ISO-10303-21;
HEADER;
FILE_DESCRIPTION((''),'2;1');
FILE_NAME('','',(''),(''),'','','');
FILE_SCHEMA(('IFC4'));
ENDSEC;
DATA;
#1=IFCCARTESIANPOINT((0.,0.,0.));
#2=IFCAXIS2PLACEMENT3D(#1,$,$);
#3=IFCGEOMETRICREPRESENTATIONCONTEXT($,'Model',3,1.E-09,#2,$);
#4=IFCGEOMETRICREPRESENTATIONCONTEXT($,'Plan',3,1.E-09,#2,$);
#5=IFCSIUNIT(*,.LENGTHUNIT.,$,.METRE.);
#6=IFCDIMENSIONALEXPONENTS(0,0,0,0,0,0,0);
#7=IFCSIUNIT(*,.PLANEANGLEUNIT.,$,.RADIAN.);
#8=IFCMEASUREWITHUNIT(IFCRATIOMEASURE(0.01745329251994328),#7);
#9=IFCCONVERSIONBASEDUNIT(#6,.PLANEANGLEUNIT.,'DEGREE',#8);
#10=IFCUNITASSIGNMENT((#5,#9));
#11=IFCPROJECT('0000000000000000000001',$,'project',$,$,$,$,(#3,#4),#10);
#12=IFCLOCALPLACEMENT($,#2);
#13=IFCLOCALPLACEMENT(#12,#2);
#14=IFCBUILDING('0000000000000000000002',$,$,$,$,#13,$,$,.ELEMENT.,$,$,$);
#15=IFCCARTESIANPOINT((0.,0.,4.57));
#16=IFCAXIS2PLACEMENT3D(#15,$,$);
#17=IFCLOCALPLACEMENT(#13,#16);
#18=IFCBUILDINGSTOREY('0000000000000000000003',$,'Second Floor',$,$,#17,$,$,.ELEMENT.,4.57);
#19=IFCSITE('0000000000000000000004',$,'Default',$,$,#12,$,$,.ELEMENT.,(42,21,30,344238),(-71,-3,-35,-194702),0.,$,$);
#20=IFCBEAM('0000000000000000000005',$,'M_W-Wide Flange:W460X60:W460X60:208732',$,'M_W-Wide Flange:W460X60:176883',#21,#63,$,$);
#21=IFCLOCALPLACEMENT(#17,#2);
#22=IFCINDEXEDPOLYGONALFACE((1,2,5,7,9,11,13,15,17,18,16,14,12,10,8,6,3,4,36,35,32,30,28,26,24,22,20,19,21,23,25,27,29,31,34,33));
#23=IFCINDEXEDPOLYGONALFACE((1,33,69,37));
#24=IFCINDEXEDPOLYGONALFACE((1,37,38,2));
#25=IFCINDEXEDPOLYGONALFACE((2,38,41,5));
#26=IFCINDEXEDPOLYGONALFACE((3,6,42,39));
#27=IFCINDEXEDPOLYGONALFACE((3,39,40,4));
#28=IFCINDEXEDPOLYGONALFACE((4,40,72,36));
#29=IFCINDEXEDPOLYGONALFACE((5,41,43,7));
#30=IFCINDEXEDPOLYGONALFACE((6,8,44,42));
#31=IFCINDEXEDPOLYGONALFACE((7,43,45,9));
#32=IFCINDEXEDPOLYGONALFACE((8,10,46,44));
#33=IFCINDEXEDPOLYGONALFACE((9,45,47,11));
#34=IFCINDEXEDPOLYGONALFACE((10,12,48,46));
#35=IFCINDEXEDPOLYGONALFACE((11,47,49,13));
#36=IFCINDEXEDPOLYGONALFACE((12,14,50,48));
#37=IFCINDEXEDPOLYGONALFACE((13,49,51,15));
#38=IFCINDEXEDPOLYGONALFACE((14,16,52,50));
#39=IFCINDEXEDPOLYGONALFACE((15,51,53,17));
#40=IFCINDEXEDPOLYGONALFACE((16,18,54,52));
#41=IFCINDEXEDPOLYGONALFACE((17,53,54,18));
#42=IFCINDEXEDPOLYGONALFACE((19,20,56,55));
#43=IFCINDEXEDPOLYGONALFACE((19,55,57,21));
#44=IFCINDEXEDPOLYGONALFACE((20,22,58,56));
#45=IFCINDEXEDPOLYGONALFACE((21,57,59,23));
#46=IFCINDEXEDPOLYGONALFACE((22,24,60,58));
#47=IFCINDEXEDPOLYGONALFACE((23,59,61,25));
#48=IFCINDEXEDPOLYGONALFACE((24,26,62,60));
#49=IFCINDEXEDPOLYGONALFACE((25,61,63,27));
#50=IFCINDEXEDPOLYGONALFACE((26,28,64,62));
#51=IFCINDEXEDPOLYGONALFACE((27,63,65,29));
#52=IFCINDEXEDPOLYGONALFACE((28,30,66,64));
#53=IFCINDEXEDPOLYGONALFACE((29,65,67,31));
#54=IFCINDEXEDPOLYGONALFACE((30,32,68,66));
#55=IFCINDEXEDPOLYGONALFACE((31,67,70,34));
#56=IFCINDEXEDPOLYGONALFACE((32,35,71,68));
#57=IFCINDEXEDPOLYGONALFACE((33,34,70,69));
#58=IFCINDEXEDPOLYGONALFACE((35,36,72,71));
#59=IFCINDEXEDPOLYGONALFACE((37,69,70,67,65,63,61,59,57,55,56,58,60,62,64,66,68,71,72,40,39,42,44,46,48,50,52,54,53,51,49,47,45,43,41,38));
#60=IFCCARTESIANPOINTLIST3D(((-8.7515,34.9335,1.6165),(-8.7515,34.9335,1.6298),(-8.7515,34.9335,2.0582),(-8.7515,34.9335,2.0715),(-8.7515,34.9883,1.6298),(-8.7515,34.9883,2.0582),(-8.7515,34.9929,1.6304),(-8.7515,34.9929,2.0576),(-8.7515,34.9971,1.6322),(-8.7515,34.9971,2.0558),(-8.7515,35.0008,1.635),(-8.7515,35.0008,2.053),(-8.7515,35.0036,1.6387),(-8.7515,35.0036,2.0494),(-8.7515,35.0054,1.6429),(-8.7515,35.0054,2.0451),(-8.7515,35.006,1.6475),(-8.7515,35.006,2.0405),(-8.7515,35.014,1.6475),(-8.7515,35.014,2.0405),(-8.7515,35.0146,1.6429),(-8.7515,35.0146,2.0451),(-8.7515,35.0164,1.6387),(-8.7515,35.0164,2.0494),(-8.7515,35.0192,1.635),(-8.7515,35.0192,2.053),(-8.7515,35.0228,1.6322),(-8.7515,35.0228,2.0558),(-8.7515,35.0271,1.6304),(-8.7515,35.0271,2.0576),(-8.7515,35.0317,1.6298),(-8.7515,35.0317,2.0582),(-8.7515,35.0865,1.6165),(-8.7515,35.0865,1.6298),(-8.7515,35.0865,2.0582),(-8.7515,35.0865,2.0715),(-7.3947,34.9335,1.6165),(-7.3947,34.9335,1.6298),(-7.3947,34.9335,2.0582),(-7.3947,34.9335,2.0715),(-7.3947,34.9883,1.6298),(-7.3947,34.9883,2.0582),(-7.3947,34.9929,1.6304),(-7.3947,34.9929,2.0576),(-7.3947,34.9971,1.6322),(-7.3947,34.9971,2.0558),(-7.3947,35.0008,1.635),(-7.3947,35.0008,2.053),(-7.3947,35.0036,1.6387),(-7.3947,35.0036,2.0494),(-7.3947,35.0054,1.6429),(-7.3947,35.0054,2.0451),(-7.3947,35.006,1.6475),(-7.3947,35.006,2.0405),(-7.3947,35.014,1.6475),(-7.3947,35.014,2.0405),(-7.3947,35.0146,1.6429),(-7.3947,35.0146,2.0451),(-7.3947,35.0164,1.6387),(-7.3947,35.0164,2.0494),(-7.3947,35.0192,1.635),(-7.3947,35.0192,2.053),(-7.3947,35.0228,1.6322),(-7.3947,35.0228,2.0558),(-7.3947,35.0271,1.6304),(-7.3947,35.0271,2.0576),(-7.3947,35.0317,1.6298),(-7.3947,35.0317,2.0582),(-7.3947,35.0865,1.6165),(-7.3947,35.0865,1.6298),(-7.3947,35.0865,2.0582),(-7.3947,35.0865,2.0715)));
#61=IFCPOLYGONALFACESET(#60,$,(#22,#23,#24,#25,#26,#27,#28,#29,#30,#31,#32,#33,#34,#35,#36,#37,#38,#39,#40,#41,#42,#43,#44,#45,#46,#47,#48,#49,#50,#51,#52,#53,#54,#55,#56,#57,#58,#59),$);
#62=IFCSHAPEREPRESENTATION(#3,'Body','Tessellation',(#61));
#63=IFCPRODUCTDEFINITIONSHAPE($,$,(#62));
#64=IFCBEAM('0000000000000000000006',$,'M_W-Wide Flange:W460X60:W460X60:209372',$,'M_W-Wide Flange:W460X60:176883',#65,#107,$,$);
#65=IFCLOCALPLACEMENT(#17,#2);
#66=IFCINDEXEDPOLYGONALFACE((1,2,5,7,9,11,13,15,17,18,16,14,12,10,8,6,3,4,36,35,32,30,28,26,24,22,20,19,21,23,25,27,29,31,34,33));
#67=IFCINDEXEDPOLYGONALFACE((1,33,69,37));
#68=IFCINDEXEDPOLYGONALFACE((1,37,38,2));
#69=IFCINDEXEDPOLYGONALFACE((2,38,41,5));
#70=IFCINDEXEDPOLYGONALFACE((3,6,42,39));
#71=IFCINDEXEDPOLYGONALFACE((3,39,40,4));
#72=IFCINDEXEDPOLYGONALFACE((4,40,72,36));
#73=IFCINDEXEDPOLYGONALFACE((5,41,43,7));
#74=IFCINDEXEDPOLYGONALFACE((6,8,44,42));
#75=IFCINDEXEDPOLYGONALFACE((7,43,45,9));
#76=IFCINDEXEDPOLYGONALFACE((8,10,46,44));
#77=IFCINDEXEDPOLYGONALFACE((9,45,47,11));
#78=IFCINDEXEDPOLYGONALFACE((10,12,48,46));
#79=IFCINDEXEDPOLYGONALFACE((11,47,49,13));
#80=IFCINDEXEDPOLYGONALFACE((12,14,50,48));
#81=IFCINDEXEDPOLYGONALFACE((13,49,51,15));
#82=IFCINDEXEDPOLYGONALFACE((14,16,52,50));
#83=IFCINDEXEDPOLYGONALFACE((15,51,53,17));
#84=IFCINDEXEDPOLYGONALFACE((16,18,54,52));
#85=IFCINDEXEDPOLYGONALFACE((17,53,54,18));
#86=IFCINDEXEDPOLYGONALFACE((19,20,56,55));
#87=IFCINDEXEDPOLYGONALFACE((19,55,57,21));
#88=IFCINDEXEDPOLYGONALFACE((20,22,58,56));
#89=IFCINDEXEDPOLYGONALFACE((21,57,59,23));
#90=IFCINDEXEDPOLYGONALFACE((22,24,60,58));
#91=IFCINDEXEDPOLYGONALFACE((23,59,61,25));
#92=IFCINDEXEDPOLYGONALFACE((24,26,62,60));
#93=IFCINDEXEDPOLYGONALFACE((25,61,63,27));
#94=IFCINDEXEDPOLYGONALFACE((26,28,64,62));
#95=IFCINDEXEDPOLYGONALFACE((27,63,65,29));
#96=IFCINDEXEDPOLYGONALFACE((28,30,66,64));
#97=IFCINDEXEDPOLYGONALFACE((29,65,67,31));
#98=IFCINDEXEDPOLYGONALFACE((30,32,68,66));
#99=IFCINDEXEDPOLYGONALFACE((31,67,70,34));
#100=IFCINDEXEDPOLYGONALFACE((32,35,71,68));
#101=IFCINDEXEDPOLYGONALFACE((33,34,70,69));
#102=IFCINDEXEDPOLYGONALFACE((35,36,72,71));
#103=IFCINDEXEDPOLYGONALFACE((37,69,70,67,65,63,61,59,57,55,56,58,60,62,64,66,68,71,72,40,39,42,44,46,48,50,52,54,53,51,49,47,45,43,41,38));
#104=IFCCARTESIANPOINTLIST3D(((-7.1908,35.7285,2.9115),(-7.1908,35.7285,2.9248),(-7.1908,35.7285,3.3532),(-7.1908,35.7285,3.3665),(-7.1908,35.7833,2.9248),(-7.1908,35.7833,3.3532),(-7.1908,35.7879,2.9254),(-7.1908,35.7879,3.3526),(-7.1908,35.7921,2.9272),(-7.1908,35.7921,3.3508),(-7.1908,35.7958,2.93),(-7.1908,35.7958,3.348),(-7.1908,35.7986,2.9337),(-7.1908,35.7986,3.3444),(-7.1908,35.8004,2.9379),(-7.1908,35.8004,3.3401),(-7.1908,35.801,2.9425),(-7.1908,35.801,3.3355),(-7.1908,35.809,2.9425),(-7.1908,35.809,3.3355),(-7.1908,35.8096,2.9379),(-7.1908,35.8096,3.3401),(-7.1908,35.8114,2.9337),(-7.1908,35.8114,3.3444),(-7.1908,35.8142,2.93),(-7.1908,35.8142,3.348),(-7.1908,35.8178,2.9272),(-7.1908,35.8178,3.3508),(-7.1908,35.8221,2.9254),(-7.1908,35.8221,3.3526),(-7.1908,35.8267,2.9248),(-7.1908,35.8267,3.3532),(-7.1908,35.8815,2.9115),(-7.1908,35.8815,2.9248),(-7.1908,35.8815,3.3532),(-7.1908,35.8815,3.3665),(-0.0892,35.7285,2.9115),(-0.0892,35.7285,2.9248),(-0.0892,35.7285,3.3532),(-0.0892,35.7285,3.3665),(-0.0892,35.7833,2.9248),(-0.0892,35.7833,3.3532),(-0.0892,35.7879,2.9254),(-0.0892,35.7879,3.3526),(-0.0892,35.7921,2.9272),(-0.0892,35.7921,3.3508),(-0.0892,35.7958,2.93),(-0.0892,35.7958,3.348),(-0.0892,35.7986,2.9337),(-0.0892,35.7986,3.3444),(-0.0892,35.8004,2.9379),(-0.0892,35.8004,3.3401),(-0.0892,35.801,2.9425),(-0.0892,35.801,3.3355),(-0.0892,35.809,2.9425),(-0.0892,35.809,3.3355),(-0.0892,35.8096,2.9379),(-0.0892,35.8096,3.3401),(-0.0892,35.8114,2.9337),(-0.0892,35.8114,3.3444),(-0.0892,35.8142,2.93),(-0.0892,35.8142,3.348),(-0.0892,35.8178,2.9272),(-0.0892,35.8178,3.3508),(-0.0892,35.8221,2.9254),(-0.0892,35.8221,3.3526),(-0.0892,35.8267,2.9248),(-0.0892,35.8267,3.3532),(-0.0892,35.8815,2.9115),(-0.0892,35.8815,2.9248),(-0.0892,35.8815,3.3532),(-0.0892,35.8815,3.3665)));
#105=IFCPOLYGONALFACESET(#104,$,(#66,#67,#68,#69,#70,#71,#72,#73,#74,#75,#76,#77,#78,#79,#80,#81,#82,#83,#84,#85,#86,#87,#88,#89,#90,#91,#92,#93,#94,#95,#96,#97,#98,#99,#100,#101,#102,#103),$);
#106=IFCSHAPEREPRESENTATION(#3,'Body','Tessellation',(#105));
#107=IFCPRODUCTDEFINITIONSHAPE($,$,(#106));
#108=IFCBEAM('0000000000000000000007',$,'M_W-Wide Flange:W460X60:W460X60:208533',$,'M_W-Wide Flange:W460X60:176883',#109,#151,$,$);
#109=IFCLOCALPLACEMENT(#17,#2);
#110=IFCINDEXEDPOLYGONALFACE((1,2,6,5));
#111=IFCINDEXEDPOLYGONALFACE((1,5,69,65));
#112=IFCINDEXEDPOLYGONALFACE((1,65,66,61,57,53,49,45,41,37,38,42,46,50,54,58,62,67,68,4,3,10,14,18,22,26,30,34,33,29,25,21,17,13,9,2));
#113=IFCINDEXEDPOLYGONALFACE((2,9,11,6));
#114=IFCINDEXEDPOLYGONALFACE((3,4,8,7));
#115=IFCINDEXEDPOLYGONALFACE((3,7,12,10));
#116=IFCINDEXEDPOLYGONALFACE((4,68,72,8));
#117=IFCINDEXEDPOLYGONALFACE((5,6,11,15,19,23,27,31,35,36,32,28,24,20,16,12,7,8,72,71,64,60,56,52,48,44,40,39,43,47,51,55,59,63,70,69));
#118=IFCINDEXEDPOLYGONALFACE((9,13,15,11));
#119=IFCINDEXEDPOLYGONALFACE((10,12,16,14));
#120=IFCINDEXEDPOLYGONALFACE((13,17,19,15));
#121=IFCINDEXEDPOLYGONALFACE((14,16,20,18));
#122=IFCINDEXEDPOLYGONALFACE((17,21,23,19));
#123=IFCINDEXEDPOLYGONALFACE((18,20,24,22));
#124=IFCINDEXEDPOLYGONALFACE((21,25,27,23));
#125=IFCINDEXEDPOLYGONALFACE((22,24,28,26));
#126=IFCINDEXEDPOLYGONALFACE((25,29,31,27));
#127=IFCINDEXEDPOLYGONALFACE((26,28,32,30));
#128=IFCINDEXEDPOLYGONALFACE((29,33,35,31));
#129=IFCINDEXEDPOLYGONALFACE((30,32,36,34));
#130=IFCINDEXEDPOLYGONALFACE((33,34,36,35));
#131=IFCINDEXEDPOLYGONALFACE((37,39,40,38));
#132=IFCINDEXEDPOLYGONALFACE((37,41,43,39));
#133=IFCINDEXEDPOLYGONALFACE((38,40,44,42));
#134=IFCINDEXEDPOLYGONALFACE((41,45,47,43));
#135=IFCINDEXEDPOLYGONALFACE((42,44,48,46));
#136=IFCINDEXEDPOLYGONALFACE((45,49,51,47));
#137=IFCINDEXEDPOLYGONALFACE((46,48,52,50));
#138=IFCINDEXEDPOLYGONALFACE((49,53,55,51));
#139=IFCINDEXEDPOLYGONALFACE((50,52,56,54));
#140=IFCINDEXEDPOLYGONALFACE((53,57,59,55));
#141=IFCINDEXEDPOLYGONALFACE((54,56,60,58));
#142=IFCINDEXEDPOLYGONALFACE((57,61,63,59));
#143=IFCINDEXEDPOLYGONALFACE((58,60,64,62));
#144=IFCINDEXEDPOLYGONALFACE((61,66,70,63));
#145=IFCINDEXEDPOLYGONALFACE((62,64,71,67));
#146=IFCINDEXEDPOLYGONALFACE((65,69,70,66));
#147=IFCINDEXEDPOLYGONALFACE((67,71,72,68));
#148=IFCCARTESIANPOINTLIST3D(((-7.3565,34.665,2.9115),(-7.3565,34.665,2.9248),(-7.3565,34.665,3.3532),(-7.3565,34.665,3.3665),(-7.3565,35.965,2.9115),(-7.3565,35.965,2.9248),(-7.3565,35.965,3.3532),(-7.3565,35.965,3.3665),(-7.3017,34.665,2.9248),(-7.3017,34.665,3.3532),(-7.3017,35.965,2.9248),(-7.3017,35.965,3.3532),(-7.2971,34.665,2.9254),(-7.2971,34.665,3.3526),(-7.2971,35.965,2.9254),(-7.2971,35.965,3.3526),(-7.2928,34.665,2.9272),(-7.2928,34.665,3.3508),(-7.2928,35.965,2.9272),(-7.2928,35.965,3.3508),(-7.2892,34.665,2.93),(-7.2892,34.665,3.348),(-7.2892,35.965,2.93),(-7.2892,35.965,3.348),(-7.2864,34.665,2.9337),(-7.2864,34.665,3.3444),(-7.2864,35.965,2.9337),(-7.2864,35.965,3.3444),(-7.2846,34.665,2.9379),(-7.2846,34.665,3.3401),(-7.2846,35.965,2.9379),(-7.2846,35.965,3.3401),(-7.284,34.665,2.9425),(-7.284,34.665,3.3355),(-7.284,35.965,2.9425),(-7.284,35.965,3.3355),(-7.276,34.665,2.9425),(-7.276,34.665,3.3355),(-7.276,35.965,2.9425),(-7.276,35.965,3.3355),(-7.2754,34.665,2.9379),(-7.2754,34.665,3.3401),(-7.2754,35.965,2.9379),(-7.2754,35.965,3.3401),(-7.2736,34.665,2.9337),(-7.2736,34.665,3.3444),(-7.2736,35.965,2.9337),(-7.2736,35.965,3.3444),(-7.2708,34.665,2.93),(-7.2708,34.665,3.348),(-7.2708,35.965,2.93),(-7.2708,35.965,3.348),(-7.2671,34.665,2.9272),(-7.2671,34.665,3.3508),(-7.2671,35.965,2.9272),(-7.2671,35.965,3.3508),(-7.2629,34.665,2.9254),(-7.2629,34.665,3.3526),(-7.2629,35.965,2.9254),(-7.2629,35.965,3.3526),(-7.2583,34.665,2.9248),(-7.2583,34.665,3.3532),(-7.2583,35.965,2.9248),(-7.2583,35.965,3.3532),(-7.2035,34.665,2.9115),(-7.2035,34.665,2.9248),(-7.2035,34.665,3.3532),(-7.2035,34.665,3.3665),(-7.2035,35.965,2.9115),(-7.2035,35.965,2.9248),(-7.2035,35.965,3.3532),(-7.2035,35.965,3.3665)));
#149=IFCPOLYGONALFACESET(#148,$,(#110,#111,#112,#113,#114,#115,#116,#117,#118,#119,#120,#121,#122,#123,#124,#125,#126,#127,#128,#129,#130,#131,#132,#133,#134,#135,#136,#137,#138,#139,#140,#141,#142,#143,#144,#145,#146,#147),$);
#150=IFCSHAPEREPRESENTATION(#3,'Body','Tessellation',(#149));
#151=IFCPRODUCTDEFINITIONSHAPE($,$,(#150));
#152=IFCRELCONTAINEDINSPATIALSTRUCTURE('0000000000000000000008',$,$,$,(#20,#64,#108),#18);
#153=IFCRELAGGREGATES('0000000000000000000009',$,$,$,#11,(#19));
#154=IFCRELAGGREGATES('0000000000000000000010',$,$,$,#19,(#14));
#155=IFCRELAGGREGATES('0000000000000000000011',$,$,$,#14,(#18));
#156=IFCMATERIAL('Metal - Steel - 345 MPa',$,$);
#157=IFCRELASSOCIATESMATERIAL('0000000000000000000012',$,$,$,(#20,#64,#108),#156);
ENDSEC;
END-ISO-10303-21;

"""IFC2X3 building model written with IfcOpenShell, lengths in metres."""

from ifc_helpers import new_model, entity, si_unit, converted_unit, frame, frame_2d, origin, place, context, project, spatial, polyline, circle_curve, parameter, trimmed, segment, composite_curve, outline, extrude, material, element, save


model = new_model("IFC2X3")

# Units and contexts
model_context = context("Model", 3, precision=1e-09, world=origin())
plan_context = context("Plan", 3, precision=1e-09, world=origin())
ifc_project = project(units=[si_unit("LENGTHUNIT", "METRE"), converted_unit("PLANEANGLEUNIT", "DEGREE", entity("IfcRatioMeasure", 0.01745329251994328), si_unit("PLANEANGLEUNIT", "RADIAN"), dimensions=[0, 0, 0, 0, 0, 0, 0])], contexts=[model_context, plan_context])

# Site, building, storey
site_placement = place(None, origin())
site = spatial("IfcSite", under=ifc_project, at=site_placement, Name="Default", CompositionType="ELEMENT", RefLatitude=(42, 21, 30, 344238), RefLongitude=(-71, -3, -35, -194702), RefElevation=0.0)
building_placement = place(site_placement, origin())
building = spatial("IfcBuilding", under=site, at=building_placement, CompositionType="ELEMENT")
storey_placement = place(building_placement, frame((0.0, 0.0, 4.57)))
storey = spatial("IfcBuildingStorey", under=building, at=storey_placement, Name="Second Floor", CompositionType="ELEMENT", Elevation=4.57)

# Shared definitions
ifc_material = material(Name="Metal - Steel - 345 MPa")

# Beams
beam_1_placement = place(storey_placement, frame((-7.273, 35.01, 2.0715), z_axis=(0.0, 0.0, 1.0), x_axis=(0.0, -1.0, 0.0)))
element("IfcBeam", 1, at=beam_1_placement, inside=storey, material=ifc_material, Name="M_W-Wide Flange:W460X60:W460X60:208732", ObjectType="M_W-Wide Flange:W460X60:176883", context=model_context, shape_type="SweptSolid", body=[
    extrude(outline(composite_curve([segment(polyline([(-0.0765, -0.2142), (-0.0765, -0.2275)]), True, "CONTINUOUS"), segment(polyline([(-0.0765, -0.2275), (0.0765, -0.2275)]), True, "CONTINUOUS"), segment(polyline([(0.0765, -0.2275), (0.0765, -0.2142)]), True, "CONTINUOUS"), segment(polyline([(0.0765, -0.2142), (0.0217, -0.2142)]), True, "CONTINUOUS"), segment(trimmed(circle_curve(frame_2d((0.0217, -0.1965), x_axis=(1.0, 0.0)), 0.0177), [parameter(180.0)], [parameter(270.0)], True, "PARAMETER"), False, "CONTINUOUS"), segment(polyline([(0.004, -0.1965), (0.004, 0.1965)]), True, "CONTINUOUS"), segment(trimmed(circle_curve(frame_2d((0.0217, 0.1965), x_axis=(1.0, 0.0)), 0.0177), [parameter(90.0)], [parameter(180.0)], True, "PARAMETER"), False, "CONTINUOUS"), segment(polyline([(0.0217, 0.2142), (0.0765, 0.2142)]), True, "CONTINUOUS"), segment(polyline([(0.0765, 0.2142), (0.0765, 0.2275)]), True, "CONTINUOUS"), segment(polyline([(0.0765, 0.2275), (-0.0765, 0.2275)]), True, "CONTINUOUS"), segment(polyline([(-0.0765, 0.2275), (-0.0765, 0.2142)]), True, "CONTINUOUS"), segment(polyline([(-0.0765, 0.2142), (-0.0217, 0.2142)]), True, "CONTINUOUS"), segment(trimmed(circle_curve(frame_2d((-0.0217, 0.1965), x_axis=(1.0, 0.0)), 0.0177), [parameter(360.0)], [parameter(90.0)], True, "PARAMETER"), False, "CONTINUOUS"), segment(polyline([(-0.004, 0.1965), (-0.004, -0.1965)]), True, "CONTINUOUS"), segment(trimmed(circle_curve(frame_2d((-0.0217, -0.1965), x_axis=(1.0, 0.0)), 0.0177), [parameter(270.0)], [parameter(0.0)], True, "PARAMETER"), False, "CONTINUOUS"), segment(polyline([(-0.0217, -0.2142), (-0.0765, -0.2142)]), True, "CONTINUOUS")], self_intersect=False)), frame((0.0, -1.4785, -0.2275), z_axis=(0.0, -1.0, 0.0), x_axis=(1.0, 0.0, 0.0)), (0.0, 0.0, -1.0), 1.3568),
])
beam_2_placement = place(storey_placement, frame((-7.2774, 35.805, 3.3665), z_axis=(0.0, 0.0, 1.0), x_axis=(0.0, -1.0, 0.0)))
element("IfcBeam", 2, at=beam_2_placement, inside=storey, material=ifc_material, Name="M_W-Wide Flange:W460X60:W460X60:209372", ObjectType="M_W-Wide Flange:W460X60:176883", context=model_context, shape_type="SweptSolid", body=[
    extrude(outline(composite_curve([segment(polyline([(-0.0765, -0.2142), (-0.0765, -0.2275)]), True, "CONTINUOUS"), segment(polyline([(-0.0765, -0.2275), (0.0765, -0.2275)]), True, "CONTINUOUS"), segment(polyline([(0.0765, -0.2275), (0.0765, -0.2142)]), True, "CONTINUOUS"), segment(polyline([(0.0765, -0.2142), (0.0217, -0.2142)]), True, "CONTINUOUS"), segment(trimmed(circle_curve(frame_2d((0.0217, -0.1965), x_axis=(1.0, 0.0)), 0.0177), [parameter(180.0)], [parameter(270.0)], True, "PARAMETER"), False, "CONTINUOUS"), segment(polyline([(0.004, -0.1965), (0.004, 0.1965)]), True, "CONTINUOUS"), segment(trimmed(circle_curve(frame_2d((0.0217, 0.1965), x_axis=(1.0, 0.0)), 0.0177), [parameter(90.0)], [parameter(180.0)], True, "PARAMETER"), False, "CONTINUOUS"), segment(polyline([(0.0217, 0.2142), (0.0765, 0.2142)]), True, "CONTINUOUS"), segment(polyline([(0.0765, 0.2142), (0.0765, 0.2275)]), True, "CONTINUOUS"), segment(polyline([(0.0765, 0.2275), (-0.0765, 0.2275)]), True, "CONTINUOUS"), segment(polyline([(-0.0765, 0.2275), (-0.0765, 0.2142)]), True, "CONTINUOUS"), segment(polyline([(-0.0765, 0.2142), (-0.0217, 0.2142)]), True, "CONTINUOUS"), segment(trimmed(circle_curve(frame_2d((-0.0217, 0.1965), x_axis=(1.0, 0.0)), 0.0177), [parameter(360.0)], [parameter(90.0)], True, "PARAMETER"), False, "CONTINUOUS"), segment(polyline([(-0.004, 0.1965), (-0.004, -0.1965)]), True, "CONTINUOUS"), segment(trimmed(circle_curve(frame_2d((-0.0217, -0.1965), x_axis=(1.0, 0.0)), 0.0177), [parameter(270.0)], [parameter(0.0)], True, "PARAMETER"), False, "CONTINUOUS"), segment(polyline([(-0.0217, -0.2142), (-0.0765, -0.2142)]), True, "CONTINUOUS")], self_intersect=False)), frame((0.0, 0.0866, -0.2275), z_axis=(0.0, -1.0, 0.0), x_axis=(1.0, 0.0, 0.0)), (0.0, 0.0, -1.0), 7.1016),
])
beam_3_placement = place(storey_placement, frame((-7.28, 35.0646, 3.3665), z_axis=(0.0, 0.0, 1.0), x_axis=(-1.0, 0.0, 0.0)))
element("IfcBeam", 3, at=beam_3_placement, inside=storey, material=ifc_material, Name="M_W-Wide Flange:W460X60:W460X60:208533", ObjectType="M_W-Wide Flange:W460X60:176883", context=model_context, shape_type="SweptSolid", body=[
    extrude(outline(composite_curve([segment(polyline([(0.2142, -0.0765), (0.2275, -0.0765)]), True, "CONTINUOUS"), segment(polyline([(0.2275, -0.0765), (0.2275, 0.0765)]), True, "CONTINUOUS"), segment(polyline([(0.2275, 0.0765), (0.2142, 0.0765)]), True, "CONTINUOUS"), segment(polyline([(0.2142, 0.0765), (0.2142, 0.0217)]), True, "CONTINUOUS"), segment(trimmed(circle_curve(frame_2d((0.1965, 0.0217), x_axis=(0.0, 1.0)), 0.0177), [parameter(180.0)], [parameter(270.0)], True, "PARAMETER"), False, "CONTINUOUS"), segment(polyline([(0.1965, 0.004), (-0.1965, 0.004)]), True, "CONTINUOUS"), segment(trimmed(circle_curve(frame_2d((-0.1965, 0.0217), x_axis=(0.0, 1.0)), 0.0177), [parameter(90.0)], [parameter(180.0)], True, "PARAMETER"), False, "CONTINUOUS"), segment(polyline([(-0.2142, 0.0217), (-0.2142, 0.0765)]), True, "CONTINUOUS"), segment(polyline([(-0.2142, 0.0765), (-0.2275, 0.0765)]), True, "CONTINUOUS"), segment(polyline([(-0.2275, 0.0765), (-0.2275, -0.0765)]), True, "CONTINUOUS"), segment(polyline([(-0.2275, -0.0765), (-0.2142, -0.0765)]), True, "CONTINUOUS"), segment(polyline([(-0.2142, -0.0765), (-0.2142, -0.0217)]), True, "CONTINUOUS"), segment(trimmed(circle_curve(frame_2d((-0.1965, -0.0217), x_axis=(0.0, 1.0)), 0.0177), [parameter(360.0)], [parameter(90.0)], True, "PARAMETER"), False, "CONTINUOUS"), segment(polyline([(-0.1965, -0.004), (0.1965, -0.004)]), True, "CONTINUOUS"), segment(trimmed(circle_curve(frame_2d((0.1965, -0.0217), x_axis=(0.0, 1.0)), 0.0177), [parameter(270.0)], [parameter(0.0)], True, "PARAMETER"), False, "CONTINUOUS"), segment(polyline([(0.2142, -0.0217), (0.2142, -0.0765)]), True, "CONTINUOUS")], self_intersect=False)), frame((0.0, 0.3996, -0.2275), z_axis=(0.0, -1.0, 0.0), x_axis=(0.0, 0.0, -1.0)), (0.0, 0.0, 1.0), 1.3),
])

save(model, "model.ifc")
